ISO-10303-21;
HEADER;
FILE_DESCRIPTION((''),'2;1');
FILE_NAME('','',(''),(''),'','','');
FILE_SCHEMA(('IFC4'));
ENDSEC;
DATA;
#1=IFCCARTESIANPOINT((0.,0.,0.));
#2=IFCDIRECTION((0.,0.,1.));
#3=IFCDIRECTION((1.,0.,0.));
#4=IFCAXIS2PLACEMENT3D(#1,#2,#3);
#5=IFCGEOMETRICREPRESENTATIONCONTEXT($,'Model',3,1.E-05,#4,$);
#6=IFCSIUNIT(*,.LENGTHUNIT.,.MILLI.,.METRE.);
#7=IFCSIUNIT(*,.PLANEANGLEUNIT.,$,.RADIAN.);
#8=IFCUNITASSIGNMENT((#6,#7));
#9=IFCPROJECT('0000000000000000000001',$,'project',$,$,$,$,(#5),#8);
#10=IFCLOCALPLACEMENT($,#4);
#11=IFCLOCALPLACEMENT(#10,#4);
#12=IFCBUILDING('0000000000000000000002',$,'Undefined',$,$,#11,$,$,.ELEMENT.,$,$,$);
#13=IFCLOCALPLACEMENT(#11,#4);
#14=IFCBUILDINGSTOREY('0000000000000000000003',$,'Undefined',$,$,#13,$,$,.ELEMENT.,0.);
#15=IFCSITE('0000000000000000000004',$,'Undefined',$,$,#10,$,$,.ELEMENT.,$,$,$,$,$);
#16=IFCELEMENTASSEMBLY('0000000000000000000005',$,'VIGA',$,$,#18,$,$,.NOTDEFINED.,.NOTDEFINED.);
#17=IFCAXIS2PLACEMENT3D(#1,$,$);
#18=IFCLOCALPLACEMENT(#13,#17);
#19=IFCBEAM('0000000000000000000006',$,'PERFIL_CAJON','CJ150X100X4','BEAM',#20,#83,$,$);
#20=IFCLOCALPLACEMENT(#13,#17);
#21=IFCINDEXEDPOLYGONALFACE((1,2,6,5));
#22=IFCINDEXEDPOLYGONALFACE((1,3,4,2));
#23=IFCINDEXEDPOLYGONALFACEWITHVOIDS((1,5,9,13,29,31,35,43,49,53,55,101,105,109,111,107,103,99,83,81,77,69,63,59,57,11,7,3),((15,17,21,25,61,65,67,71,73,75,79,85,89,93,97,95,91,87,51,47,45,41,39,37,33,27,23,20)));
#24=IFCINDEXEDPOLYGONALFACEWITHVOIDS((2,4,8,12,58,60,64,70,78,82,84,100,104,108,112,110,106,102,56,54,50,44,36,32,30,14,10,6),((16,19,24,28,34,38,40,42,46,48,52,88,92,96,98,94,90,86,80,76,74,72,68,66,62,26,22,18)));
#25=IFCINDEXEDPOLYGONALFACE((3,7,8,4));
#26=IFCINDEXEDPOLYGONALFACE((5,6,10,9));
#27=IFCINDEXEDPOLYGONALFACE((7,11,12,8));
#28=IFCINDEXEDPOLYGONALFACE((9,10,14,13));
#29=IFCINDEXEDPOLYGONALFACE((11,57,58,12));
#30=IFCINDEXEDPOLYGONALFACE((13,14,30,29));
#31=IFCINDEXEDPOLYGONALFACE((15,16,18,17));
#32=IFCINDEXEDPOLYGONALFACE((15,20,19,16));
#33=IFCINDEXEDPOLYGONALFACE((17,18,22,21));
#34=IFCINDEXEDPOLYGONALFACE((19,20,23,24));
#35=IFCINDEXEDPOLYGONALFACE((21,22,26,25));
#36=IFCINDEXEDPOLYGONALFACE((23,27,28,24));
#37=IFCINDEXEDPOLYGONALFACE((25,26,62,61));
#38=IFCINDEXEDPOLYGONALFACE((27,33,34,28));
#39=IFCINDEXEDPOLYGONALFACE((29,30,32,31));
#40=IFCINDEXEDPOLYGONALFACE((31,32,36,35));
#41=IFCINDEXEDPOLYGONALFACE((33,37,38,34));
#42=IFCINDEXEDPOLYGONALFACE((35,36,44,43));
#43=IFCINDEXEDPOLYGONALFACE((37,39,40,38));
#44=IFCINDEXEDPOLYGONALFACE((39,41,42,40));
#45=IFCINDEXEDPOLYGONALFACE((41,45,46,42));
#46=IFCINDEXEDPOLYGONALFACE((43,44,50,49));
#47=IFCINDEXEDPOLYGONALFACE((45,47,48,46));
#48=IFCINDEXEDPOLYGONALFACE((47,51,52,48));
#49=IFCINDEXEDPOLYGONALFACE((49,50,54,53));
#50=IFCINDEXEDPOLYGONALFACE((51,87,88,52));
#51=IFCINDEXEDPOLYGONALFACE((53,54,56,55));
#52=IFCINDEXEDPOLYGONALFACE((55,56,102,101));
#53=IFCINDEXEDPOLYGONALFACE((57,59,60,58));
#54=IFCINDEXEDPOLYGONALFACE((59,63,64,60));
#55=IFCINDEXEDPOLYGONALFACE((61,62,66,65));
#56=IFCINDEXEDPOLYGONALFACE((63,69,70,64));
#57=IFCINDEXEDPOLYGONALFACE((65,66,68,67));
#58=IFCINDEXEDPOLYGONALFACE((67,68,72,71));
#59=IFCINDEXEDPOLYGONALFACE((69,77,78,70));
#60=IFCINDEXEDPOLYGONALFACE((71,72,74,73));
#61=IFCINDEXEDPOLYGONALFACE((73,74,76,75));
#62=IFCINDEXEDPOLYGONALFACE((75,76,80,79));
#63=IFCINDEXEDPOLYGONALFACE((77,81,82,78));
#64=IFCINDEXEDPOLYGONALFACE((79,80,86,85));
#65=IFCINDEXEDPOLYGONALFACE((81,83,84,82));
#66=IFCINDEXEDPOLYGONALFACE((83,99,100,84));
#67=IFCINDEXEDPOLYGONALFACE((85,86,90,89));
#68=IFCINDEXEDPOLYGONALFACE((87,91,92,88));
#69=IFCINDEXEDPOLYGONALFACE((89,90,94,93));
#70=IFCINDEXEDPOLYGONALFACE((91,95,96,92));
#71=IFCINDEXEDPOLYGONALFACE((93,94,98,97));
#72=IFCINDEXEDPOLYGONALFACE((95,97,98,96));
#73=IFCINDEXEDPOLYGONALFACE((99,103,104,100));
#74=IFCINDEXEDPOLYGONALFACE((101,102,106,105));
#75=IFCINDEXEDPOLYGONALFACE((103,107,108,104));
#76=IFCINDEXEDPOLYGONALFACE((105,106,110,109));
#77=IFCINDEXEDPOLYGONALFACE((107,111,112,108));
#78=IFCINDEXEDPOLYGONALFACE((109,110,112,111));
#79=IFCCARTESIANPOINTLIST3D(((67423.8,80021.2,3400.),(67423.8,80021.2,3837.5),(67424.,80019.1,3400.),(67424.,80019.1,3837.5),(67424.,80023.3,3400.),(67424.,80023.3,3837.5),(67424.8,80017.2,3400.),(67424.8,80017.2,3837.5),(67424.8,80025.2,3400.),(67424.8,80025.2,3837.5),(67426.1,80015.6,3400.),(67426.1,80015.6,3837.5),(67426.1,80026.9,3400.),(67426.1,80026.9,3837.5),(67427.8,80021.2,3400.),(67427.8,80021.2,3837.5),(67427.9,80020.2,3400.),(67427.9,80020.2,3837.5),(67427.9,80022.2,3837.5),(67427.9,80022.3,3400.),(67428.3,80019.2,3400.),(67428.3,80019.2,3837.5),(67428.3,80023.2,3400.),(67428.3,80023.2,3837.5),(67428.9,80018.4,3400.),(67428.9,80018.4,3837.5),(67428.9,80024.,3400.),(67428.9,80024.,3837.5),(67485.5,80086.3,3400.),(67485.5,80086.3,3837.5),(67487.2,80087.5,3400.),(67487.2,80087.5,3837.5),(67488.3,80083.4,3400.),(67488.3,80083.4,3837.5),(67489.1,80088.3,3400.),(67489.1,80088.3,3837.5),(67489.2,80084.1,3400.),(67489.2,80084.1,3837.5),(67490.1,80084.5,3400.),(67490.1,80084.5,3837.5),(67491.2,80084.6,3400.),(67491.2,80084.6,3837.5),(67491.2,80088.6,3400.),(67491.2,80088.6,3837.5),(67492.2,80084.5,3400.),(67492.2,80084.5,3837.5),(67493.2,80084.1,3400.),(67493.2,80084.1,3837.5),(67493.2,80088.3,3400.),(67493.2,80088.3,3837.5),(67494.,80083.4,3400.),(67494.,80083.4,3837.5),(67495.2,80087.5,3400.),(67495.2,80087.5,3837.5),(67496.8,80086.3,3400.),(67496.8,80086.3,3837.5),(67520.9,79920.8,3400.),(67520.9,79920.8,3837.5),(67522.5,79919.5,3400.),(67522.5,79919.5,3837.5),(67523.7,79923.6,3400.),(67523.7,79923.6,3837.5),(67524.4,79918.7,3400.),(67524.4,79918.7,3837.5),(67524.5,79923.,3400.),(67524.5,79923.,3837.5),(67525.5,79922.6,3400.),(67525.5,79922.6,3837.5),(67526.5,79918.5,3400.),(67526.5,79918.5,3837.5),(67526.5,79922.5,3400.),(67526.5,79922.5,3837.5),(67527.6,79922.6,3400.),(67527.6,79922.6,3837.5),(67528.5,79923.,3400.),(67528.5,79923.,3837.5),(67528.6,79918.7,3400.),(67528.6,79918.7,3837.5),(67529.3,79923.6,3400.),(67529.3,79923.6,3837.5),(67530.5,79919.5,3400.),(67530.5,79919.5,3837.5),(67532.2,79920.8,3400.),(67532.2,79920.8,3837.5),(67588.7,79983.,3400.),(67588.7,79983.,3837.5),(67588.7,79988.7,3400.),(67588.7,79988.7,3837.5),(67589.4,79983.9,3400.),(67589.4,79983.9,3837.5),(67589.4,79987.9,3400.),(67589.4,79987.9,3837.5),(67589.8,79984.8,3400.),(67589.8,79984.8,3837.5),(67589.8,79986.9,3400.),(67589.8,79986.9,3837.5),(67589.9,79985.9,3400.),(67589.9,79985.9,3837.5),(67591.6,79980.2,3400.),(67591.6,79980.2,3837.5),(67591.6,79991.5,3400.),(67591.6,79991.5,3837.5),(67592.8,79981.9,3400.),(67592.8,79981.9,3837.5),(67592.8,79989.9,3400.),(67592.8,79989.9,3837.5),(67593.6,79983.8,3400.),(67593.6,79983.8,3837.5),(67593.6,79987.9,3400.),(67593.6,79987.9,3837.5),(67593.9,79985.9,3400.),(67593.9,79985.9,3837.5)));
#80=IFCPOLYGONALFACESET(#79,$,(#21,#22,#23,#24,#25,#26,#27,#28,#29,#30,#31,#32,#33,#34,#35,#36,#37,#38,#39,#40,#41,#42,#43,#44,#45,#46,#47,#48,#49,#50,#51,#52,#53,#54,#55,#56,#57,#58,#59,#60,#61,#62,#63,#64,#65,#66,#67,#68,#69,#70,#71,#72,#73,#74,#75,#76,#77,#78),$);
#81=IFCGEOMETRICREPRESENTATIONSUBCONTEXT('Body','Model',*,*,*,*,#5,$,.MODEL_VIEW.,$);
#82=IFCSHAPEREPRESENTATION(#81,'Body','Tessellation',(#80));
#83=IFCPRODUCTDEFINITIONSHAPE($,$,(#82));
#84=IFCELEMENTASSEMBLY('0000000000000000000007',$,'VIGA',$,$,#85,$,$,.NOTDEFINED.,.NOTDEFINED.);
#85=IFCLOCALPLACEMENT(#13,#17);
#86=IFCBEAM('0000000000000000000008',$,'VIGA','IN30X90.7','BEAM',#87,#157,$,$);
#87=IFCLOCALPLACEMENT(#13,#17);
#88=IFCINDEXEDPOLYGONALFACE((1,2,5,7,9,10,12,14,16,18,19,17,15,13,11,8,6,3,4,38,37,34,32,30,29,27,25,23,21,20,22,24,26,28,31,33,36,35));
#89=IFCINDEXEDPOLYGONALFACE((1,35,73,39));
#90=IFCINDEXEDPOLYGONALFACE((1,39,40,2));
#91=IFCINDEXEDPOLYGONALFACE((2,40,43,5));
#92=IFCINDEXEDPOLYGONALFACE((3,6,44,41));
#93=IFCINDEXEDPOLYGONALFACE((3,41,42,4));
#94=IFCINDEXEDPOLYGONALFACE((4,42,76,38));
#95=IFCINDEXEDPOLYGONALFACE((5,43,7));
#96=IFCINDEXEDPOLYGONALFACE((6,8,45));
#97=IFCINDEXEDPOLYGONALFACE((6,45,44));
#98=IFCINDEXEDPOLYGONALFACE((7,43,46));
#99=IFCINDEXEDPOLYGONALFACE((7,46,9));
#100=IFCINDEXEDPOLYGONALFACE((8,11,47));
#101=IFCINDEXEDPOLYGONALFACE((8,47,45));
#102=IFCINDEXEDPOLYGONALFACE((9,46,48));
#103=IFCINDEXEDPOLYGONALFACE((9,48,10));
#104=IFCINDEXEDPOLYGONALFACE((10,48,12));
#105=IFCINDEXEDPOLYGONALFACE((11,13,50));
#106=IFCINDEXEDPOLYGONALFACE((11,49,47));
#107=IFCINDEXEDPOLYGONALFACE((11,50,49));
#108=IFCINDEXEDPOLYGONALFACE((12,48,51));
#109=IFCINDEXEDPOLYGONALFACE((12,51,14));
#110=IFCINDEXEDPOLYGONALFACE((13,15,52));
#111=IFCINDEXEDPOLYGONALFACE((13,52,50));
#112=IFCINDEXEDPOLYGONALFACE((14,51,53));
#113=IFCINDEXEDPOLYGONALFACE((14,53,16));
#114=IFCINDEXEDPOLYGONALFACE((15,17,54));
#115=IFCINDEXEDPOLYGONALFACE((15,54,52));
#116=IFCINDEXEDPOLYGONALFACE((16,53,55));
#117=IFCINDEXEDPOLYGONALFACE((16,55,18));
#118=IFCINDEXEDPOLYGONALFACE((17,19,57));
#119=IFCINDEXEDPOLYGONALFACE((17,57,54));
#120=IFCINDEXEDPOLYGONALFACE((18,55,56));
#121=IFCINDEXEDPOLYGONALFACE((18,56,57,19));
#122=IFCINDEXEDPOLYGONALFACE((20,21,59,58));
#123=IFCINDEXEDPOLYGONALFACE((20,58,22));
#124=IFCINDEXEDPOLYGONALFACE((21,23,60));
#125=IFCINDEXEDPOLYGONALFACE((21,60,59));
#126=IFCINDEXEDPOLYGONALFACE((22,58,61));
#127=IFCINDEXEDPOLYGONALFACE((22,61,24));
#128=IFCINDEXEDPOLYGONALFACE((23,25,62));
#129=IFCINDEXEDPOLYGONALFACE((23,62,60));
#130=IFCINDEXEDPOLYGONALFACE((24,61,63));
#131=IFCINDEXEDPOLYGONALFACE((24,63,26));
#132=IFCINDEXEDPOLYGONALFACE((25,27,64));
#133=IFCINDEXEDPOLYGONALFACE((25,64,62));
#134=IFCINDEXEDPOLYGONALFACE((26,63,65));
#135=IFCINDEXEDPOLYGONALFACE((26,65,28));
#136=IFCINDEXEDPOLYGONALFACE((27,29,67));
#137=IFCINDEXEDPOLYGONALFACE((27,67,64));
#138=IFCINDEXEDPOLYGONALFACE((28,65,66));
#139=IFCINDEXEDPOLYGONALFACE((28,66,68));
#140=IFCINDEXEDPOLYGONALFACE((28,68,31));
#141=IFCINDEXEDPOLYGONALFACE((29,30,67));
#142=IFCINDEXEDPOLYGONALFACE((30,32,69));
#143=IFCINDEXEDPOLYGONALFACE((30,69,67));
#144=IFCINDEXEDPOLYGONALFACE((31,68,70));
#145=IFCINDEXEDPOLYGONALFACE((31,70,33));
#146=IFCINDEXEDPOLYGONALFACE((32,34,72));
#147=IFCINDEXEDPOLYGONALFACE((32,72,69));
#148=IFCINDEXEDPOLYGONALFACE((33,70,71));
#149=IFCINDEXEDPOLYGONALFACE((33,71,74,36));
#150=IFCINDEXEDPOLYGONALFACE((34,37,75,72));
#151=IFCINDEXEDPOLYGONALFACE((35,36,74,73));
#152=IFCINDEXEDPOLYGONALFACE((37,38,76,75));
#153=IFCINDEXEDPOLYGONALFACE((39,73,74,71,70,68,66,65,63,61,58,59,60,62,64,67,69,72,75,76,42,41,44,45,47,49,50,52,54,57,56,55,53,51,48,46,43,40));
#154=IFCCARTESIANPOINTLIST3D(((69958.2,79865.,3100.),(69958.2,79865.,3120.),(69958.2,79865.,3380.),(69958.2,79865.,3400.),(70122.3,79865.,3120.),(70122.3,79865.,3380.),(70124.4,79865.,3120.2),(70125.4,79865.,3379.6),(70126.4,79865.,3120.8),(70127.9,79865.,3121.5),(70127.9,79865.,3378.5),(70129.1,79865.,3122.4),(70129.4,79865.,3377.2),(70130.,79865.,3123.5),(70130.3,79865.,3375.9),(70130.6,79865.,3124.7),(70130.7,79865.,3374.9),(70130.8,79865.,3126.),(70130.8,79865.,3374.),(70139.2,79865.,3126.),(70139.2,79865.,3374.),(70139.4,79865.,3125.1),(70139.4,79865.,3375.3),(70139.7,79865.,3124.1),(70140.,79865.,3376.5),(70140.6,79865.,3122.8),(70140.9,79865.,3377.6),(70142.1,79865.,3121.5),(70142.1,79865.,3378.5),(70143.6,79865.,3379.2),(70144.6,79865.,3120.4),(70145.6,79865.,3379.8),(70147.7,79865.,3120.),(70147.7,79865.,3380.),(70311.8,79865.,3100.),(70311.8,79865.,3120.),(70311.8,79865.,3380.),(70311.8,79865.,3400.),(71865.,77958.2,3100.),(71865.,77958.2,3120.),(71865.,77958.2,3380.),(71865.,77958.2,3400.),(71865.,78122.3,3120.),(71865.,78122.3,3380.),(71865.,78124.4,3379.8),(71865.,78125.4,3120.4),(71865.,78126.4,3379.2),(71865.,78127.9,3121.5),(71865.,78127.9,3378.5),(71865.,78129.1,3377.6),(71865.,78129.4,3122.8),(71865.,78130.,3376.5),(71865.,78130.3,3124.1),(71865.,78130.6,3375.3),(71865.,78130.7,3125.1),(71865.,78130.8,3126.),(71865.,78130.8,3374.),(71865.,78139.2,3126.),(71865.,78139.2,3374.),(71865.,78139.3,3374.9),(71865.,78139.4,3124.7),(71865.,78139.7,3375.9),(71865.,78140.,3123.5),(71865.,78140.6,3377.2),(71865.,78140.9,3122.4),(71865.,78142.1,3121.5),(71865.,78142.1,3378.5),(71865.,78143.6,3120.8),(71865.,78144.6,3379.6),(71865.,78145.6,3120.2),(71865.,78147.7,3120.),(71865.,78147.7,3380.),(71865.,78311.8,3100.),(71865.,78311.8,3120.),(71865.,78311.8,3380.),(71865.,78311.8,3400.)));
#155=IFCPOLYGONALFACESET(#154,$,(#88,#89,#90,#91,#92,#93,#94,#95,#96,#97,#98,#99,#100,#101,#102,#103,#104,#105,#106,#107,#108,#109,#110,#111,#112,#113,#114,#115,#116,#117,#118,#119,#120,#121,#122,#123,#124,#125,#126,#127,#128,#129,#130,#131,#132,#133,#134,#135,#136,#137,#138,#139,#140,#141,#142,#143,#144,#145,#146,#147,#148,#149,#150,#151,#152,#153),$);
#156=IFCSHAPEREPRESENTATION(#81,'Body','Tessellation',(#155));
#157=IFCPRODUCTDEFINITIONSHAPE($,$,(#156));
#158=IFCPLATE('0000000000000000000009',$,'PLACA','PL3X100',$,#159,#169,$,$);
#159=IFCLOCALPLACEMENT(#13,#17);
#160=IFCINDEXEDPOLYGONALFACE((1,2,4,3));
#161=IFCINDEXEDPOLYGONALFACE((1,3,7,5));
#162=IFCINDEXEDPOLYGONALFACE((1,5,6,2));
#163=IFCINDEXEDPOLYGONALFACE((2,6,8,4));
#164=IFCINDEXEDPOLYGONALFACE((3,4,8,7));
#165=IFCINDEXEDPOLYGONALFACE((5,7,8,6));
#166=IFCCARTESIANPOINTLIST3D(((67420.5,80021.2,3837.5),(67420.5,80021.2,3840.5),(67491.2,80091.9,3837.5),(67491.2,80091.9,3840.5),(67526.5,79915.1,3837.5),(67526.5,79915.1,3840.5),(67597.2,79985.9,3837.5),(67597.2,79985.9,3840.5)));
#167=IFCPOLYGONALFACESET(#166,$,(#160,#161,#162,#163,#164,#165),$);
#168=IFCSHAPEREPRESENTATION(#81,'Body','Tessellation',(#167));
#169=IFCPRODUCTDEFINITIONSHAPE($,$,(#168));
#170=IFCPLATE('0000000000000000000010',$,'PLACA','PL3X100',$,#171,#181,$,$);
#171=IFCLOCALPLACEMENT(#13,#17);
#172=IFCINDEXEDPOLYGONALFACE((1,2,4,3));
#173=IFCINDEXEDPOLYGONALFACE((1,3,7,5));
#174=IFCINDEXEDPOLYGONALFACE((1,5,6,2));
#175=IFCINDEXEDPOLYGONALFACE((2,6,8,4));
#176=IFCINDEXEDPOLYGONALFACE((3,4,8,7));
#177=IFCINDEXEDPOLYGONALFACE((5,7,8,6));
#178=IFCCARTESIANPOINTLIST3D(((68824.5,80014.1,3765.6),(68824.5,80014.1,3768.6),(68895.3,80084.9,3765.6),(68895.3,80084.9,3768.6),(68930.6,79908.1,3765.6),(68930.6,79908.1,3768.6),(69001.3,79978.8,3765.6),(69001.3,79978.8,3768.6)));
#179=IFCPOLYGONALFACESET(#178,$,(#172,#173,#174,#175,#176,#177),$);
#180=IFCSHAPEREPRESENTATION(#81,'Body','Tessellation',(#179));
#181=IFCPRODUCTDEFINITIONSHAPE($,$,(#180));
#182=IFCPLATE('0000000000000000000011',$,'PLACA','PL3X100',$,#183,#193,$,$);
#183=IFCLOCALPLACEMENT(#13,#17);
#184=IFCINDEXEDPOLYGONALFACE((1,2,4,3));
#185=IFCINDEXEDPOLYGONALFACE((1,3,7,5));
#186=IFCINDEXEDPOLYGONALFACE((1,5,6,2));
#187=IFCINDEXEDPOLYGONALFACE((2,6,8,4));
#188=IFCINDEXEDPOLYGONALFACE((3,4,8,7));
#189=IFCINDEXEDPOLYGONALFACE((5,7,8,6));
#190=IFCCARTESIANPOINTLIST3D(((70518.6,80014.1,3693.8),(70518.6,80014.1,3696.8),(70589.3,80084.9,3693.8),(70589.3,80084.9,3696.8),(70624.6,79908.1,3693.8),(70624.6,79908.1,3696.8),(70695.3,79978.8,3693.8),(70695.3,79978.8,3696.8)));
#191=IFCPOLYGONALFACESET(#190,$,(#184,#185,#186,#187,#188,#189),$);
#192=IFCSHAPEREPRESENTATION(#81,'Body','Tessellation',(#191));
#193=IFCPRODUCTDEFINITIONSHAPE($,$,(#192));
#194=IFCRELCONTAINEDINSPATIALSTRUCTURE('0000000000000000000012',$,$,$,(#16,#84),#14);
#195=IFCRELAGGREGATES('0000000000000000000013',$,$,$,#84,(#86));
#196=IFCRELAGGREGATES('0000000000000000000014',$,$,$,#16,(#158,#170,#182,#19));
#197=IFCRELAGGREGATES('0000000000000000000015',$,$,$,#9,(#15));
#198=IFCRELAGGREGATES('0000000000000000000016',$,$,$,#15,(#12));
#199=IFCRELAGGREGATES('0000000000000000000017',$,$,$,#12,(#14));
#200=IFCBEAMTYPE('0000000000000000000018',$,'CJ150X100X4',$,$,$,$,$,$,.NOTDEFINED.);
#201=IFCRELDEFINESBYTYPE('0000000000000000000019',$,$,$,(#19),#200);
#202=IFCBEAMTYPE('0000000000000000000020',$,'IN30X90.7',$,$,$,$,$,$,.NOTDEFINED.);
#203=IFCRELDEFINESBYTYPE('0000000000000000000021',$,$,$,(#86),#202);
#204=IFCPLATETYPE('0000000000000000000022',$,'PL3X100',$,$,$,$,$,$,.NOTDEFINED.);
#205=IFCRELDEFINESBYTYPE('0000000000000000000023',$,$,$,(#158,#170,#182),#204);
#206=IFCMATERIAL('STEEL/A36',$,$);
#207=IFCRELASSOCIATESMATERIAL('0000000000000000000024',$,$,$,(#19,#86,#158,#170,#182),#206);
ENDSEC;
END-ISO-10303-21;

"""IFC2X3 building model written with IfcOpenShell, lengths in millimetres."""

from ifc_helpers import new_model, si_unit, frame, origin_with_axes, origin_2d_with_axis, place, context, subcontext, project, spatial, polyline, hollow_rectangle, i_section, outline, extrude, clip, halfspace, material, type_object, element, aggregate, save


model = new_model("IFC2X3")

# Units and contexts
model_context = context("Model", 3, precision=1e-05, world=origin_with_axes())
body_context = subcontext(model_context, "Body", "Model", "MODEL_VIEW")
ifc_project = project(units=[si_unit("LENGTHUNIT", "METRE", prefix="MILLI"), si_unit("PLANEANGLEUNIT", "RADIAN")], contexts=[model_context])

# Site, building, storey
site_placement = place(None, origin_with_axes())
site = spatial("IfcSite", under=ifc_project, at=site_placement, Name="Undefined", CompositionType="ELEMENT")
building_placement = place(site_placement, origin_with_axes())
building = spatial("IfcBuilding", under=site, at=building_placement, Name="Undefined", CompositionType="ELEMENT")
storey_placement = place(building_placement, origin_with_axes())
storey = spatial("IfcBuildingStorey", under=building, at=storey_placement, Name="Undefined", CompositionType="ELEMENT", Elevation=0.0)

# Element assembly, beam
assembly_1_placement = place(storey_placement, origin_with_axes())
assembly_1 = element("IfcElementAssembly", 1, at=assembly_1_placement, inside=storey, Name="VIGA", AssemblyPlace="NOTDEFINED", PredefinedType="NOTDEFINED")
ifc_material_1 = material(Name="STEEL/A36")
beam_type_1 = type_object("IfcBeamType", Name="CJ150X100X4", PredefinedType="NOTDEFINED")
beam_1_placement = place(assembly_1_placement, frame((67508.8, 80003.5, 3837.5), z_axis=(-0.707107, 0.707107, 0.0), x_axis=(0.000006, 0.000006, -1.0)))
beam_1 = element("IfcBeam", 2, at=beam_1_placement, type_object=beam_type_1, material=ifc_material_1, Name="PERFIL_CAJON", Description="CJ150X100X4", ObjectType="BEAM", context=body_context, shape_type="SweptSolid", body=[
    extrude(hollow_rectangle(XDim=100.0, YDim=150.0, WallThickness=4.0, InnerFilletRadius=4.0, OuterFilletRadius=8.0, at=origin_2d_with_axis()), frame((437.5, 0.0, 0.0), z_axis=(-1.0, 0.0, 0.0), x_axis=(0.0, -1.0, 0.0)), (0.0, 0.0, 1.0), 437.5),
])

# Element assembly, beam
assembly_2_placement = place(storey_placement, origin_with_axes())
assembly_2 = element("IfcElementAssembly", 3, at=assembly_2_placement, inside=storey, Name="VIGA", AssemblyPlace="NOTDEFINED", PredefinedType="NOTDEFINED")
beam_type_2 = type_object("IfcBeamType", Name="IN30X90.7", PredefinedType="NOTDEFINED")
beam_2_placement = place(assembly_2_placement, frame((70000.0, 80000.0, 3250.0), z_axis=(0.0, 0.0, 1.0), x_axis=(0.707107, -0.707107, 0.0)))
beam_2 = element("IfcBeam", 4, at=beam_2_placement, type_object=beam_type_2, material=ifc_material_1, Name="VIGA", Description="IN30X90.7", ObjectType="BEAM", context=body_context, shape_type="Clipping", body=[
    clip(clip(extrude(i_section(OverallWidth=250.0, OverallDepth=300.0, WebThickness=6.0, FlangeThickness=20.0, FilletRadius=6.0, at=origin_2d_with_axis()), frame((2890.0, 0.0, 0.0), z_axis=(-1.0, 0.0, 0.0), x_axis=(0.0, -1.0, 0.0)), (0.0, 0.0, 1.0), 2951.6), halfspace(frame((2730.8, -93.3, 250.0), z_axis=(0.707107, 0.707107, 0.0), x_axis=(-0.707107, 0.707107, 0.0)), False)), halfspace(frame((97.6, -93.3, 250.0), z_axis=(-0.707107, 0.707107, 0.0), x_axis=(-0.707107, -0.707107, 0.0)), False)),
])
aggregate(assembly_2, [beam_2])

# Plates
plate_type_1 = type_object("IfcPlateType", Name="PL3X100", PredefinedType="NOTDEFINED")
plate_1_placement = place(assembly_1_placement, frame((67597.2, 79985.9, 3839.0), z_axis=(0.000006, 0.000006, -1.0), x_axis=(-0.707107, -0.707107, -0.000009)))
plate_1 = element("IfcPlate", 5, at=plate_1_placement, type_object=plate_type_1, material=ifc_material_1, Name="PLACA", Description="PL3X100", context=body_context, shape_type="SweptSolid", body=[
    extrude(outline(polyline([(0.0, 0.0), (100.0, 0.0), (100.0, 150.0), (0.0, 150.0), (0.0, 0.0)])), frame((0.0, 0.0, -1.5), z_axis=(0.0, 0.0, 1.0), x_axis=(1.0, 0.0, 0.0)), (0.0, 0.0, 1.0), 3.0),
])
plate_2_placement = place(assembly_1_placement, frame((69001.3, 79978.8, 3767.1), z_axis=(0.000008, 0.000008, -1.0), x_axis=(-0.707107, -0.707107, -0.000012)))
plate_2 = element("IfcPlate", 6, at=plate_2_placement, type_object=plate_type_1, material=ifc_material_1, Name="PLACA", Description="PL3X100", context=body_context, shape_type="SweptSolid", body=[
    extrude(outline(polyline([(0.0, 0.0), (100.0, 0.0), (100.0, 150.0), (0.0, 150.0), (0.0, 0.0)])), frame((0.0, 0.0, -1.5), z_axis=(0.0, 0.0, 1.0), x_axis=(1.0, 0.0, 0.0)), (0.0, 0.0, 1.0), 3.0),
])
plate_3_placement = place(assembly_1_placement, frame((70695.3, 79978.8, 3695.3), z_axis=(0.000011, 0.000011, -1.0), x_axis=(-0.707107, -0.707107, -0.000015)))
plate_3 = element("IfcPlate", 7, at=plate_3_placement, type_object=plate_type_1, material=ifc_material_1, Name="PLACA", Description="PL3X100", context=body_context, shape_type="SweptSolid", body=[
    extrude(outline(polyline([(0.0, 0.0), (100.0, 0.0), (100.0, 150.0), (0.0, 150.0), (0.0, 0.0)])), frame((0.0, 0.0, -1.5), z_axis=(0.0, 0.0, 1.0), x_axis=(1.0, 0.0, 0.0)), (0.0, 0.0, 1.0), 3.0),
])

aggregate(assembly_1, [plate_1, plate_2, plate_3, beam_1])

save(model, "model.ifc")
